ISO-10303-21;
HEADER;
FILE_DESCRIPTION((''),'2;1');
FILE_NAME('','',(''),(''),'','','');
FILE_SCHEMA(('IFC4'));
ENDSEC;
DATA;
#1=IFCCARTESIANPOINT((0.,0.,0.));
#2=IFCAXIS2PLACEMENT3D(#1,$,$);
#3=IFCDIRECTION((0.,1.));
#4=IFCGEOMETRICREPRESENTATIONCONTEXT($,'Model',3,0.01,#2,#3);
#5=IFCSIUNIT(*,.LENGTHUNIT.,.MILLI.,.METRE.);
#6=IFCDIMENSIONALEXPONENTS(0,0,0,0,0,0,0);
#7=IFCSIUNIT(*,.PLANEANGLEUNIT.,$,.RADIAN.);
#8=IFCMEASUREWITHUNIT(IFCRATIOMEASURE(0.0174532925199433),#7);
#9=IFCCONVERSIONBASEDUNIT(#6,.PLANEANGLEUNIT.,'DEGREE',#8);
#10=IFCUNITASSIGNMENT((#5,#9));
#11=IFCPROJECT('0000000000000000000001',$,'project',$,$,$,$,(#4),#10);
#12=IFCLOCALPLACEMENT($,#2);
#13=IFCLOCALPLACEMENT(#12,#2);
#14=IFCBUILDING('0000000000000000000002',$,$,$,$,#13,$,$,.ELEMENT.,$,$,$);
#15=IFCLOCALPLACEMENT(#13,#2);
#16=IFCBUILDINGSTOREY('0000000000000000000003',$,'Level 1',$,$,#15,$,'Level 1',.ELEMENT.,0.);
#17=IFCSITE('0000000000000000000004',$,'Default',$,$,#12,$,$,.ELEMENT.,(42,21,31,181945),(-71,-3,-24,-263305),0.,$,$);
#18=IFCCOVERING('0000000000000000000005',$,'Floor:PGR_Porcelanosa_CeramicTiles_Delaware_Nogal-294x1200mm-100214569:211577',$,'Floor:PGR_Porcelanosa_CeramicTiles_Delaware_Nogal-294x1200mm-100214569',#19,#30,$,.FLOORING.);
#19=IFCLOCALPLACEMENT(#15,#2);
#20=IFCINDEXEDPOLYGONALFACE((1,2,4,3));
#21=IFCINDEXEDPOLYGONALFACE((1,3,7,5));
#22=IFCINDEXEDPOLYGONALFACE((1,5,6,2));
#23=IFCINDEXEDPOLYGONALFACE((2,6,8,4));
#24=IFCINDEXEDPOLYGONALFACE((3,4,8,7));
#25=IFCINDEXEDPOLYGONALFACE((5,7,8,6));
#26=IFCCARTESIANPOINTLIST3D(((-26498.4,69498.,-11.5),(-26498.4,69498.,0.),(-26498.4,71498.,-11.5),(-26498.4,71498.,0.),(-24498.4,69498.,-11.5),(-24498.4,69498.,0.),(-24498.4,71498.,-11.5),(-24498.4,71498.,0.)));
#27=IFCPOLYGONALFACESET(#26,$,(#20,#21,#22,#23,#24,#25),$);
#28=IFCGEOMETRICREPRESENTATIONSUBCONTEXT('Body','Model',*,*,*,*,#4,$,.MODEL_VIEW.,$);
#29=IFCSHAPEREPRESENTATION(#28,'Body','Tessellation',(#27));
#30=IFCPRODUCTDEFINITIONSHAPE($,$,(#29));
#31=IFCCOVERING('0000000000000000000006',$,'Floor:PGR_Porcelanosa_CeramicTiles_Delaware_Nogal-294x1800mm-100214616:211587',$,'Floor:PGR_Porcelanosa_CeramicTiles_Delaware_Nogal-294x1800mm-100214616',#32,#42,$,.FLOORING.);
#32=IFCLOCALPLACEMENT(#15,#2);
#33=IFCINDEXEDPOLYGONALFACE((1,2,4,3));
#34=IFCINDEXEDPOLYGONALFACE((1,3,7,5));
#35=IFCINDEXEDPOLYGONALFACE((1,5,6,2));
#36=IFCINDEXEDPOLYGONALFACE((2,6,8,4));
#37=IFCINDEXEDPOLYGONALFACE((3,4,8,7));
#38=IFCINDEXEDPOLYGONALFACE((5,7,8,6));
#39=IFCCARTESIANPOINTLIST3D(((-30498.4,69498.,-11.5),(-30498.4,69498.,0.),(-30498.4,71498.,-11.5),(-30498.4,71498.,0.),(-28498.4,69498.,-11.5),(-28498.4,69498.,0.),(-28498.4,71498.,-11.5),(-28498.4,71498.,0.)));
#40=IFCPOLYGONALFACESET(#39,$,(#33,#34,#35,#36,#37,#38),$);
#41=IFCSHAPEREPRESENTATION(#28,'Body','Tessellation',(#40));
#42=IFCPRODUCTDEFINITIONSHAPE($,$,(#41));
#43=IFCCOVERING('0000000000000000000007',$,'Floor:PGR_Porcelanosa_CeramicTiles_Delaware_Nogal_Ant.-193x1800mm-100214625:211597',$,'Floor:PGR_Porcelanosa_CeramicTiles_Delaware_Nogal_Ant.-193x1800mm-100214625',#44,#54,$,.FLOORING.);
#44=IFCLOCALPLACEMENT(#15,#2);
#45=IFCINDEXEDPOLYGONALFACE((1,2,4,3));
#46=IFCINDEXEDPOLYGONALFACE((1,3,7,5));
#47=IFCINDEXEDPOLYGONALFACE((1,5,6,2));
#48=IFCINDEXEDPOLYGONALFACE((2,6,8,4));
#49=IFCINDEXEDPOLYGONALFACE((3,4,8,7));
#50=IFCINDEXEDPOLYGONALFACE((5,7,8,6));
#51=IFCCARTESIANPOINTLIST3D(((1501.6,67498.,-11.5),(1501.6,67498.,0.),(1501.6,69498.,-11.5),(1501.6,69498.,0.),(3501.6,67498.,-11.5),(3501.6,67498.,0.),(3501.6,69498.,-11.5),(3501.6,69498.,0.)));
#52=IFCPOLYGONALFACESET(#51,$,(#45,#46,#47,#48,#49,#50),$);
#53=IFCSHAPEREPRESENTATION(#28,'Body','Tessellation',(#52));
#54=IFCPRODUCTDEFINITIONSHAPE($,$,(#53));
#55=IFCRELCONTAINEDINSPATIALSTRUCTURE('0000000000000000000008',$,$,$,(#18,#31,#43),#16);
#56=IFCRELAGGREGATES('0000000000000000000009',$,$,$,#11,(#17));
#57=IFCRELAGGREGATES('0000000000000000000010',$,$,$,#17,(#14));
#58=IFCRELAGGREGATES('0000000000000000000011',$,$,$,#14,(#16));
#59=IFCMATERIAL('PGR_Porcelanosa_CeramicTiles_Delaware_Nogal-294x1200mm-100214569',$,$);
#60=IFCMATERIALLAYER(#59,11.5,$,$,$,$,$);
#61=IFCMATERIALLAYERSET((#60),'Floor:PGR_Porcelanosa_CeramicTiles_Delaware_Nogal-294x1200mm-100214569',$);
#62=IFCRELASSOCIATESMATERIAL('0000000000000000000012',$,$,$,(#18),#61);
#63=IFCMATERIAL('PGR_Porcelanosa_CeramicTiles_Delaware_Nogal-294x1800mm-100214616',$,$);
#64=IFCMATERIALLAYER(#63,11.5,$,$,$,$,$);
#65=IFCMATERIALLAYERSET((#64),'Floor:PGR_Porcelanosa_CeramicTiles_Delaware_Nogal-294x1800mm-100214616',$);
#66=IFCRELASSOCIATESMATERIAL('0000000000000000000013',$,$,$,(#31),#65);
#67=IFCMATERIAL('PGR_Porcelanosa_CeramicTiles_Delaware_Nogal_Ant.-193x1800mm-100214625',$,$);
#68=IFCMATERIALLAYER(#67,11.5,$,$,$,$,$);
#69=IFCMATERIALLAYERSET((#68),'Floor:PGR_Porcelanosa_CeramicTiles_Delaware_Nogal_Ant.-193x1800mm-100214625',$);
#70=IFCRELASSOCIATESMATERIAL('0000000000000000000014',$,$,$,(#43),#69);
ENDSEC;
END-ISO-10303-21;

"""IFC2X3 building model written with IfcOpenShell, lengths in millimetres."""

from ifc_helpers import new_model, entity, si_unit, converted_unit, direction, frame, frame_2d, origin, place, context, subcontext, project, spatial, rectangle, extrude, material, layer, layer_set, layer_usage, element, save


model = new_model("IFC2X3")

# Units and contexts
model_context = context("Model", 3, precision=0.01, world=origin(), true_north=direction((0.0, 1.0)))
body_context = subcontext(model_context, "Body", "Model", "MODEL_VIEW")
ifc_project = project(units=[si_unit("LENGTHUNIT", "METRE", prefix="MILLI"), converted_unit("PLANEANGLEUNIT", "DEGREE", entity("IfcRatioMeasure", 0.0174532925199433), si_unit("PLANEANGLEUNIT", "RADIAN"), dimensions=[0, 0, 0, 0, 0, 0, 0])], contexts=[model_context])

# Site, building, storey
site_placement = place(None, origin())
site = spatial("IfcSite", under=ifc_project, at=site_placement, Name="Default", CompositionType="ELEMENT", RefLatitude=(42, 21, 31, 181945), RefLongitude=(-71, -3, -24, -263305), RefElevation=0.0)
building_placement = place(site_placement, origin())
building = spatial("IfcBuilding", under=site, at=building_placement, CompositionType="ELEMENT")
storey_placement = place(building_placement, origin())
storey = spatial("IfcBuildingStorey", under=building, at=storey_placement, Name="Level 1", LongName="Level 1", CompositionType="ELEMENT", Elevation=0.0)

# Shared definitions
ifc_material_1 = material(Name="PGR_Porcelanosa_CeramicTiles_Delaware_Nogal-294x1200mm-100214569")
ifc_material_2 = material(Name="PGR_Porcelanosa_CeramicTiles_Delaware_Nogal-294x1800mm-100214616")
ifc_material_3 = material(Name="PGR_Porcelanosa_CeramicTiles_Delaware_Nogal_Ant.-193x1800mm-100214625")

# Coverings
ifc_layer_1 = layer(ifc_material_1, 11.5)
ifc_layer_set_1 = layer_set([ifc_layer_1], Name="Floor:PGR_Porcelanosa_CeramicTiles_Delaware_Nogal-294x1200mm-100214569")
ifc_layer_usage_1 = layer_usage(ifc_layer_set_1, "AXIS3", "POSITIVE", 0.0)
covering_1_placement = place(storey_placement, origin())
element("IfcCovering", 1, at=covering_1_placement, inside=storey, material=ifc_layer_usage_1, Name="Floor:PGR_Porcelanosa_CeramicTiles_Delaware_Nogal-294x1200mm-100214569:211577", ObjectType="Floor:PGR_Porcelanosa_CeramicTiles_Delaware_Nogal-294x1200mm-100214569", PredefinedType="FLOORING", context=body_context, shape_type="SweptSolid", body=[
    extrude(rectangle(XDim=2000.0, YDim=2000.0, at=frame_2d((0.0, 0.0), x_axis=(1.0, 0.0))), frame((-25498.4, 70498.0, 0.0), z_axis=(0.0, 0.0, -1.0), x_axis=(0.0, 1.0, 0.0)), (0.0, 0.0, 1.0), 11.5),
])
ifc_layer_2 = layer(ifc_material_2, 11.5)
ifc_layer_set_2 = layer_set([ifc_layer_2], Name="Floor:PGR_Porcelanosa_CeramicTiles_Delaware_Nogal-294x1800mm-100214616")
ifc_layer_usage_2 = layer_usage(ifc_layer_set_2, "AXIS3", "POSITIVE", 0.0)
covering_2_placement = place(storey_placement, origin())
element("IfcCovering", 2, at=covering_2_placement, inside=storey, material=ifc_layer_usage_2, Name="Floor:PGR_Porcelanosa_CeramicTiles_Delaware_Nogal-294x1800mm-100214616:211587", ObjectType="Floor:PGR_Porcelanosa_CeramicTiles_Delaware_Nogal-294x1800mm-100214616", PredefinedType="FLOORING", context=body_context, shape_type="SweptSolid", body=[
    extrude(rectangle(XDim=2000.0, YDim=2000.0, at=frame_2d((0.0, 0.0), x_axis=(1.0, 0.0))), frame((-29498.4, 70498.0, 0.0), z_axis=(0.0, 0.0, -1.0), x_axis=(0.0, 1.0, 0.0)), (0.0, 0.0, 1.0), 11.5),
])
ifc_layer_3 = layer(ifc_material_3, 11.5)
ifc_layer_set_3 = layer_set([ifc_layer_3], Name="Floor:PGR_Porcelanosa_CeramicTiles_Delaware_Nogal_Ant.-193x1800mm-100214625")
ifc_layer_usage_3 = layer_usage(ifc_layer_set_3, "AXIS3", "POSITIVE", 0.0)
covering_3_placement = place(storey_placement, origin())
element("IfcCovering", 3, at=covering_3_placement, inside=storey, material=ifc_layer_usage_3, Name="Floor:PGR_Porcelanosa_CeramicTiles_Delaware_Nogal_Ant.-193x1800mm-100214625:211597", ObjectType="Floor:PGR_Porcelanosa_CeramicTiles_Delaware_Nogal_Ant.-193x1800mm-100214625", PredefinedType="FLOORING", context=body_context, shape_type="SweptSolid", body=[
    extrude(rectangle(XDim=2000.0, YDim=2000.0, at=frame_2d((0.0, 0.0), x_axis=(1.0, 0.0))), frame((2501.6, 68498.0, 0.0), z_axis=(0.0, 0.0, -1.0), x_axis=(0.0, 1.0, 0.0)), (0.0, 0.0, 1.0), 11.5),
])

save(model, "model.ifc")
